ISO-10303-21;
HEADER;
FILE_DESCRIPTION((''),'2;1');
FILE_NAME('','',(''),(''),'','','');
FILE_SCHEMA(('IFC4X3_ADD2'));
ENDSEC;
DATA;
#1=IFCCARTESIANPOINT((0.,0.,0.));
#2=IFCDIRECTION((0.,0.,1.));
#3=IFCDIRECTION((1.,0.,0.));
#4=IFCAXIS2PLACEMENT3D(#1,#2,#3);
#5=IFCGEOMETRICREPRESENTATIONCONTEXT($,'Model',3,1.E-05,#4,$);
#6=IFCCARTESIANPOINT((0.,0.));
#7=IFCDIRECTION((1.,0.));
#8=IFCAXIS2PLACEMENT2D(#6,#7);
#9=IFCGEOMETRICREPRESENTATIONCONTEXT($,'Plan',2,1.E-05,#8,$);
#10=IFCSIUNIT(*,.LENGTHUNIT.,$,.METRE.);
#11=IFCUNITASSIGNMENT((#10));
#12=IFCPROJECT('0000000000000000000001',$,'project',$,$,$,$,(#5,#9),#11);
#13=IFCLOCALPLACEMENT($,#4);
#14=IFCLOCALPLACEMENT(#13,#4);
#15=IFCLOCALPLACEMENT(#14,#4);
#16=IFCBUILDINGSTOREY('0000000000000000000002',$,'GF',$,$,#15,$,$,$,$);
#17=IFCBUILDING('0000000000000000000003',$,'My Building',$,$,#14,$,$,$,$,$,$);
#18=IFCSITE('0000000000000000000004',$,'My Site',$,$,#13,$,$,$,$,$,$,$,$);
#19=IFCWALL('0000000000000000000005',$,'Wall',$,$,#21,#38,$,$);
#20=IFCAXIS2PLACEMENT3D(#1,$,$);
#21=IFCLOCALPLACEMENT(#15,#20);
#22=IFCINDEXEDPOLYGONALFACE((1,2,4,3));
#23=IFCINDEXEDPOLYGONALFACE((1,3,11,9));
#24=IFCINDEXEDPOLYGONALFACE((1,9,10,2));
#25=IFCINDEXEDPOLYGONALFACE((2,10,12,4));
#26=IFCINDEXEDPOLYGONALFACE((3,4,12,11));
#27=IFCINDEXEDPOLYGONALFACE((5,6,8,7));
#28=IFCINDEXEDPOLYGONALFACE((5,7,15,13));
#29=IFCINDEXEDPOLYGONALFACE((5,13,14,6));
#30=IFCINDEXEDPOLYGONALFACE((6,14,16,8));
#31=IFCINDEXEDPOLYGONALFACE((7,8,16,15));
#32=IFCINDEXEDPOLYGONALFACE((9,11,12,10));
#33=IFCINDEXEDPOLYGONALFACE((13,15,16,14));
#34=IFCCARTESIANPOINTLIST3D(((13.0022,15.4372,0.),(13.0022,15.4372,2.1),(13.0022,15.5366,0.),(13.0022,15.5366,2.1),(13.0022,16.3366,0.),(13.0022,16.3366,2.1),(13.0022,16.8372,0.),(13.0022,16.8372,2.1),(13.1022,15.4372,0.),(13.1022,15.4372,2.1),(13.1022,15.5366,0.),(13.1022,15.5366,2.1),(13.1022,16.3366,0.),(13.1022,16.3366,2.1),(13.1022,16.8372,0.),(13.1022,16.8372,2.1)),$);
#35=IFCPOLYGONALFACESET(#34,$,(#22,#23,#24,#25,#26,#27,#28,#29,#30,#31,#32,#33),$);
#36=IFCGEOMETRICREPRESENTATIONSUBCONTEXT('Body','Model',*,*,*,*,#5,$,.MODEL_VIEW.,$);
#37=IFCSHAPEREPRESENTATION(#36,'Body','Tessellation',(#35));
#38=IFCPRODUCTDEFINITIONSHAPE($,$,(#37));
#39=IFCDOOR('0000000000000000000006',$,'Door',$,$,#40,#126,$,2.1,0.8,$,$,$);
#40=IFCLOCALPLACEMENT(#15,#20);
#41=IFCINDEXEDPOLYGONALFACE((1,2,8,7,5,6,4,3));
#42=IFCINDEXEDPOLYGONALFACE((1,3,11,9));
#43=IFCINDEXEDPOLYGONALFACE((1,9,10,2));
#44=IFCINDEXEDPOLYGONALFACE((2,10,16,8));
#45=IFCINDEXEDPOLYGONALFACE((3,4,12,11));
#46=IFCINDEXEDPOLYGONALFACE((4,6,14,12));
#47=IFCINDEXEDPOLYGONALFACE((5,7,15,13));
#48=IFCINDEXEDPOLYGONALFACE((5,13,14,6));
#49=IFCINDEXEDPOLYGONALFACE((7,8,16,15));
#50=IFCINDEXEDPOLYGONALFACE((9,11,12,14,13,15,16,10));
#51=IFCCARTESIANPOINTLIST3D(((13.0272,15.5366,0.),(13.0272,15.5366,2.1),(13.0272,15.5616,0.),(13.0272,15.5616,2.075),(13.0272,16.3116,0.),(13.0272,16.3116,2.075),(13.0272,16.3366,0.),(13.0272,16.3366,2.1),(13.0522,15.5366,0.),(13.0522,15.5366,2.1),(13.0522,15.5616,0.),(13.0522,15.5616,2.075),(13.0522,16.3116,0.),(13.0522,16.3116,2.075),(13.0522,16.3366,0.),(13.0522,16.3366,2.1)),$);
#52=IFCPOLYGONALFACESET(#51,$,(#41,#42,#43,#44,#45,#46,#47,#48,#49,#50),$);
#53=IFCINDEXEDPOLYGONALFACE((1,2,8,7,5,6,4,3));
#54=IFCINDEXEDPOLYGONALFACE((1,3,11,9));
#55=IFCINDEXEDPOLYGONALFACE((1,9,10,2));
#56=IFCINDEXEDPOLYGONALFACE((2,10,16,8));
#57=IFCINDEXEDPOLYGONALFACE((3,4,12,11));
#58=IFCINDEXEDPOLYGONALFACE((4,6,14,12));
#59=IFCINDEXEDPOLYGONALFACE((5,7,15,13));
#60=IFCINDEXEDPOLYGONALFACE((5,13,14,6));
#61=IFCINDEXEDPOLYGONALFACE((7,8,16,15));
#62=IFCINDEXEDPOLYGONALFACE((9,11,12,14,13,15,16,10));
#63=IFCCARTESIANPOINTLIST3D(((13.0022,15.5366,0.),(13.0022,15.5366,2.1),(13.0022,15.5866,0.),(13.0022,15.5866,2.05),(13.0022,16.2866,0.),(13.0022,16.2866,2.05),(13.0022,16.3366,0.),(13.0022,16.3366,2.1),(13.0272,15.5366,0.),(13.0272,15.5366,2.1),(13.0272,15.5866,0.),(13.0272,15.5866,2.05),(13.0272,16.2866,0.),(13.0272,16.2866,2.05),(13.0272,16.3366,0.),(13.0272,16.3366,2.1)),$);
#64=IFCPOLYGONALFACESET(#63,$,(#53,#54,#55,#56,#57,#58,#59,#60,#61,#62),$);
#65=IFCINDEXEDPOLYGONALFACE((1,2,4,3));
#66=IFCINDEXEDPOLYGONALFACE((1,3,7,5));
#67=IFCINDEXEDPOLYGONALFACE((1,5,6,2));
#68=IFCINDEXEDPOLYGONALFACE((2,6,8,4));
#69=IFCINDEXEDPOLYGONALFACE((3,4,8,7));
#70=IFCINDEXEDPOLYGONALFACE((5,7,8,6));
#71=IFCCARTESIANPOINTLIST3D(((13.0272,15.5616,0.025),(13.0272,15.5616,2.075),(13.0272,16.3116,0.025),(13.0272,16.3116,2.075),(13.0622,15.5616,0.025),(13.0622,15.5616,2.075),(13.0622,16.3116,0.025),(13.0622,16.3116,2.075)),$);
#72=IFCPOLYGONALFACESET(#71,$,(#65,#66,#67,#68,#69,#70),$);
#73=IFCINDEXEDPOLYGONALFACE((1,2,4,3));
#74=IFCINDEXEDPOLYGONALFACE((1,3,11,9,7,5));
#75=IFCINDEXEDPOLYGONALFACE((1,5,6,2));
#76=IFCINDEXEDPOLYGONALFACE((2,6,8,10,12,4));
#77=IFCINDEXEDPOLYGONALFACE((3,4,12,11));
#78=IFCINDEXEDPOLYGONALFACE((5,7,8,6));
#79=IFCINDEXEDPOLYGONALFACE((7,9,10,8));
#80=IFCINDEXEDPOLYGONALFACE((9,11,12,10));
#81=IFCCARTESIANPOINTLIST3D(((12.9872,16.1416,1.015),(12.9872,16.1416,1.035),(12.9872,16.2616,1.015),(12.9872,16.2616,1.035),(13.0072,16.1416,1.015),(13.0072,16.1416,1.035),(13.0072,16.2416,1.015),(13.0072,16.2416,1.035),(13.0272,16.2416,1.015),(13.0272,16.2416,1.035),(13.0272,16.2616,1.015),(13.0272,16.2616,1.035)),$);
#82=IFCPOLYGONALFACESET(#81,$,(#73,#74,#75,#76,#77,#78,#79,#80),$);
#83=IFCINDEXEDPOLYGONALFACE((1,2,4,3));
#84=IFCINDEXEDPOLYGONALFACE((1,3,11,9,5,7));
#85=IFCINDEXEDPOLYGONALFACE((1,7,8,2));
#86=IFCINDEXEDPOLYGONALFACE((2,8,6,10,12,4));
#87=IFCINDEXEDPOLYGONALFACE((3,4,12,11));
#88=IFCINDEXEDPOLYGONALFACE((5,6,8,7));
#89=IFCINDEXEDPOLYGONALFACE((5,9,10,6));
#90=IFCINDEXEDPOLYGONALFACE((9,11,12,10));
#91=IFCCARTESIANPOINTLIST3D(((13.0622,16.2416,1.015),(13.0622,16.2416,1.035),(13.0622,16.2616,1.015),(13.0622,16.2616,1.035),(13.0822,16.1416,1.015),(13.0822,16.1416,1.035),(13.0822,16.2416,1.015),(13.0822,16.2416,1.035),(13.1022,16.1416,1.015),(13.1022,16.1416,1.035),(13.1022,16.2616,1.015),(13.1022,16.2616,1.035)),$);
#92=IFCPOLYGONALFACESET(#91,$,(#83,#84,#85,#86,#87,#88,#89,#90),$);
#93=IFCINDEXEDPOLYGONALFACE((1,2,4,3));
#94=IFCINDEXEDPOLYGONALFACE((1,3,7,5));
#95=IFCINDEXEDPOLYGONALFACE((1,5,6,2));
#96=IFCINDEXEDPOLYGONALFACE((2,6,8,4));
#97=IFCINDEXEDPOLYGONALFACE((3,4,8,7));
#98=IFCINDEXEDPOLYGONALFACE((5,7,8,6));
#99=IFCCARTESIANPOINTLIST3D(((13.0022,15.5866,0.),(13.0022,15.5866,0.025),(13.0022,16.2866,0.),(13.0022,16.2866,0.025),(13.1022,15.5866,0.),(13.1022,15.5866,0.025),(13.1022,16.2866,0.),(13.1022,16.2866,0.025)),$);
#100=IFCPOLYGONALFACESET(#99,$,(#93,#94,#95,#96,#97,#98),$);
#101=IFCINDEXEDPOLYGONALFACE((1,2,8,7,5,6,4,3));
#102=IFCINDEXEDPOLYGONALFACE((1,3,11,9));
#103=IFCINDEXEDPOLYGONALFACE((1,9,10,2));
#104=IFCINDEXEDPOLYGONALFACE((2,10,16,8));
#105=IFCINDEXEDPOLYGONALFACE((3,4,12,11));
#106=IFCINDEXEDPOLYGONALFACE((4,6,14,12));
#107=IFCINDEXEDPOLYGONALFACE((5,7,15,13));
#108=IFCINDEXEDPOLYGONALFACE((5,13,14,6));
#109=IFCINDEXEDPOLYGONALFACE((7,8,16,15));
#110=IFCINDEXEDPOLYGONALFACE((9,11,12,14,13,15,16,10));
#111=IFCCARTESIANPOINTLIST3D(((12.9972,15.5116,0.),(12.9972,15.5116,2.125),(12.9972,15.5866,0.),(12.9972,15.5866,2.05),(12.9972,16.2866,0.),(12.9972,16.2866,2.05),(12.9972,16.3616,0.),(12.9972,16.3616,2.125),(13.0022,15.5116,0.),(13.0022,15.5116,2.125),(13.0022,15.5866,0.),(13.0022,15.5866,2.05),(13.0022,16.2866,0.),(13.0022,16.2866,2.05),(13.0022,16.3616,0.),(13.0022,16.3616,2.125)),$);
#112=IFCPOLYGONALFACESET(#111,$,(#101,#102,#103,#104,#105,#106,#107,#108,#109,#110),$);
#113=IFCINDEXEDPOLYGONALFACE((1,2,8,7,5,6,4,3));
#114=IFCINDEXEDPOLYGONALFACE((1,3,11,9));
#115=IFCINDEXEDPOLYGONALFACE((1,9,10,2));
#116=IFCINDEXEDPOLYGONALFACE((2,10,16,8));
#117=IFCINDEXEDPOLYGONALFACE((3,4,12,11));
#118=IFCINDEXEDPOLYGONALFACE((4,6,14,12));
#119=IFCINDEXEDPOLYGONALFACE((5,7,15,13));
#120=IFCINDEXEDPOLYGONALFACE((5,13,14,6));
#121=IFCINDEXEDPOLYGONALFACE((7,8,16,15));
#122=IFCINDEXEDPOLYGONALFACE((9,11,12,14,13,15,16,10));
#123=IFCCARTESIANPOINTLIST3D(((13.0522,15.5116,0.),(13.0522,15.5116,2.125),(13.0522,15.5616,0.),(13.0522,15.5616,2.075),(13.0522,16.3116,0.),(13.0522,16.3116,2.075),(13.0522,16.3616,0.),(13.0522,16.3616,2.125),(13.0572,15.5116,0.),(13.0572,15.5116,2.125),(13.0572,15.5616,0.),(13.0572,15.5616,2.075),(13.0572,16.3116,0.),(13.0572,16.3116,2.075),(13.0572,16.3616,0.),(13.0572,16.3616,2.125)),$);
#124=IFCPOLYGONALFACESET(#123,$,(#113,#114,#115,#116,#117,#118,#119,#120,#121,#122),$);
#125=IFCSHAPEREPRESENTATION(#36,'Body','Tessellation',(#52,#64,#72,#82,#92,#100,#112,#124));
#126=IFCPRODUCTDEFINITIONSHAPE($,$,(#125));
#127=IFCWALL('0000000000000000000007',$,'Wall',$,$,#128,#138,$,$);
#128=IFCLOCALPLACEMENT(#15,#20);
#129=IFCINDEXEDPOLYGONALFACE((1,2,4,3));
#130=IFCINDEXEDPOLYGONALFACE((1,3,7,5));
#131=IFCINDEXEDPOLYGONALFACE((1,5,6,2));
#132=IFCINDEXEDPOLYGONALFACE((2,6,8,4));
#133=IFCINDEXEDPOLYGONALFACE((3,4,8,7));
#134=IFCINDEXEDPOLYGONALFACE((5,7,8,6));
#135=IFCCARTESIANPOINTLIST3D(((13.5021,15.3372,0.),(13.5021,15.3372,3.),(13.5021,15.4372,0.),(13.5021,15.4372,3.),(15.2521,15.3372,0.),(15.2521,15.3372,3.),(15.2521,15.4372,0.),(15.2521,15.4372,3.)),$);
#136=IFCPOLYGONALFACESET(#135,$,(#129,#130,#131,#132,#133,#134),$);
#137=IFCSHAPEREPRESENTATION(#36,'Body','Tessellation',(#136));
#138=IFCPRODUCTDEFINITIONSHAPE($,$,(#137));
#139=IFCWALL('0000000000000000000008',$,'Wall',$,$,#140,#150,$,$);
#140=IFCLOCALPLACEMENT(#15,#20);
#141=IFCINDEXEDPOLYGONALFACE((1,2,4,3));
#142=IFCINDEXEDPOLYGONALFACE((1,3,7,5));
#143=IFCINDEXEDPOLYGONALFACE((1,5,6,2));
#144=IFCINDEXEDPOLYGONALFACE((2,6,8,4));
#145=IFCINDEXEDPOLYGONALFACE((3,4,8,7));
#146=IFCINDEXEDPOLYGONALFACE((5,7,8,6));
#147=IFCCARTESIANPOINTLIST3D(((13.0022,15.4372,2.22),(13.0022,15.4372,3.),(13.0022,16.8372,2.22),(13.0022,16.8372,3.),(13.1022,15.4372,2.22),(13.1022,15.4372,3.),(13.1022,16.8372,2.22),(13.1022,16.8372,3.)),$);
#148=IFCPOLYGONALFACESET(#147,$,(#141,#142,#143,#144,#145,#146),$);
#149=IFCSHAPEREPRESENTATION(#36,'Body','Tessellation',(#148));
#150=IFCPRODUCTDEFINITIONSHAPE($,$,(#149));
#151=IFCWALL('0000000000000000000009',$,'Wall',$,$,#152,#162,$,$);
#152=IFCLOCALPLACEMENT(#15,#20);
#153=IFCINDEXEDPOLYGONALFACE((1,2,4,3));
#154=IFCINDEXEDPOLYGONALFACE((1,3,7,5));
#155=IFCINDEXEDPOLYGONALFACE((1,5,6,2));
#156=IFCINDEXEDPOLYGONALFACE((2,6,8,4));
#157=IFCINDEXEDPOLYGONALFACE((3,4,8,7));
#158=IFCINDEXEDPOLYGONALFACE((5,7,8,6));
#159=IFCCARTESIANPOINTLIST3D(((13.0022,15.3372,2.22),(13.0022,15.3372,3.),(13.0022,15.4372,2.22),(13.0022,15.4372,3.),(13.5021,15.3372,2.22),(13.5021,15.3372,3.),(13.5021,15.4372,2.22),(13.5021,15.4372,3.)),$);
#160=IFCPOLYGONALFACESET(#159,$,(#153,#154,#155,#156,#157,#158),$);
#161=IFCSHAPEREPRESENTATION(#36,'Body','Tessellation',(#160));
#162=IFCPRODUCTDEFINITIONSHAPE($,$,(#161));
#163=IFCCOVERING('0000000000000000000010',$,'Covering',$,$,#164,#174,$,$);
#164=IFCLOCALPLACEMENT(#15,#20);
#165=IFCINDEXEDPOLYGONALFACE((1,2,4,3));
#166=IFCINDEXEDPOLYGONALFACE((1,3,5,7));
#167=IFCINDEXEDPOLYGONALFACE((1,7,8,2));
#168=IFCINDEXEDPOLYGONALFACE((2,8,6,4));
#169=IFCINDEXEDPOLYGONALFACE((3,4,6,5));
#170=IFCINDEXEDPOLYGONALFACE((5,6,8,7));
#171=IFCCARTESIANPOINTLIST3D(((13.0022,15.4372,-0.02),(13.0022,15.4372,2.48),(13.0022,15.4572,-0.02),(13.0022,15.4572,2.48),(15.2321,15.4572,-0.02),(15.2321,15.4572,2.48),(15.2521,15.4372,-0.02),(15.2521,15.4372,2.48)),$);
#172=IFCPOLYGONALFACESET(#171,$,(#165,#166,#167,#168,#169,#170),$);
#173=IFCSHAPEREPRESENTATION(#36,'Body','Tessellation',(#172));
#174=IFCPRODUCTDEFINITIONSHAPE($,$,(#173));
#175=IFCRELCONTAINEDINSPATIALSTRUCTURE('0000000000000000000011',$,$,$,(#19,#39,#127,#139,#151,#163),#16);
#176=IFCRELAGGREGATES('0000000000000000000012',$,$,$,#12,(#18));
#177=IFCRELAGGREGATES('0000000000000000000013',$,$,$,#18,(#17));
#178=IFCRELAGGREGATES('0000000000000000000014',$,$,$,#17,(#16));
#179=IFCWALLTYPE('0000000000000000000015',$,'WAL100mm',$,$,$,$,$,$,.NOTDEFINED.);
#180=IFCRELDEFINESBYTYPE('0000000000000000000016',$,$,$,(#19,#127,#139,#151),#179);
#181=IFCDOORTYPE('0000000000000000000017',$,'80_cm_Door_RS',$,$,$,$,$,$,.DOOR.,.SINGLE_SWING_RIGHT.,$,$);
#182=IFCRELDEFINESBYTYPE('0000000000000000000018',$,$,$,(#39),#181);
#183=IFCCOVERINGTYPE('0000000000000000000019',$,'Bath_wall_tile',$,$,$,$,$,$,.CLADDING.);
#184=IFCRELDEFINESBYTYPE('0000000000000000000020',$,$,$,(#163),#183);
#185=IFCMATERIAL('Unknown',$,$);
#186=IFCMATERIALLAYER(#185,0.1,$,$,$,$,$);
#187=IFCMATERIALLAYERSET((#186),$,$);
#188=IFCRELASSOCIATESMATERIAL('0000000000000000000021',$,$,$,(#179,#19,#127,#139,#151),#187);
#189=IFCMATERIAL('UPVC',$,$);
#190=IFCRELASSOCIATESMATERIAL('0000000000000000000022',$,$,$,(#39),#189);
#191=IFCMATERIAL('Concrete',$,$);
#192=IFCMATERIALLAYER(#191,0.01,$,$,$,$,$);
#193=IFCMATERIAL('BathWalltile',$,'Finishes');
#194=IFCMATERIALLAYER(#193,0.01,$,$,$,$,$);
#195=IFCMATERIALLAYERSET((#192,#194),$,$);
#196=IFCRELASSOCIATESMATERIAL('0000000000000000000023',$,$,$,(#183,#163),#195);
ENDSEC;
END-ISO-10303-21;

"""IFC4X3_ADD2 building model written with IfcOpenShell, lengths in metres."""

from ifc_helpers import new_model, entity, si_unit, frame, origin_with_axes, origin_2d_with_axis, place, context, subcontext, project, spatial, line, indexed_curve, outline, extrude, shape, source, transform, mapped, material, layer, layer_set, layer_usage, type_object, type_shapes, element, fill, save


model = new_model("IFC4X3_ADD2")

# Units and contexts
model_context = context("Model", 3, precision=1e-05, world=origin_with_axes())
plan_context = context("Plan", 2, precision=1e-05, world=origin_2d_with_axis())
body_context_1 = subcontext(model_context, "Body", "Model", "MODEL_VIEW")
body_context_2 = subcontext(plan_context, "Body", "Plan", "PLAN_VIEW")
ifc_project = project(units=[si_unit("LENGTHUNIT", "METRE")], contexts=[model_context, plan_context])

# Site, building, storey
site_placement = place(None, origin_with_axes())
site = spatial("IfcSite", under=ifc_project, at=site_placement, Name="My Site")
building_placement = place(site_placement, origin_with_axes())
building = spatial("IfcBuilding", under=site, at=building_placement, Name="My Building")
storey_placement = place(building_placement, origin_with_axes())
storey = spatial("IfcBuildingStorey", under=building, at=storey_placement, Name="GF")

# Shared definitions
ifc_material_1 = material(Name="UPVC")

# Shared definitions
ifc_material_2 = material(Name="Unknown")
ifc_layer_1 = layer(ifc_material_2, 0.1)
ifc_layer_set_1 = layer_set([ifc_layer_1])
wall_type_1 = type_object("IfcWallType", Name="WAL100mm", PredefinedType="NOTDEFINED", material=ifc_layer_set_1)

# Wall, opening, door
ifc_layer_usage_1 = layer_usage(ifc_layer_set_1, "AXIS2", "POSITIVE", 0.0)
wall_1_placement = place(storey_placement, frame((13.0022, 16.8372, 0.0), z_axis=(0.0, 0.0, 1.0), x_axis=(0.0, -1.0, 0.0)))
wall_1 = element("IfcWall", 1, at=wall_1_placement, inside=storey, type_object=wall_type_1, material=ifc_layer_usage_1, Name="Wall", context=body_context_1, shape_type="SweptSolid", body=[
    extrude(outline(indexed_curve([(0.0, 0.0), (0.0, 0.1), (1.4, 0.1), (1.4, 0.0)], segments=[line(1, 2, 3, 4, 1)])), origin_with_axes(), (0.0, 0.0, 1.0), 2.1),
])
shared_shape_1 = source(origin_with_axes(), body_context_1, "Body", "SweptSolid", [
    extrude(outline(indexed_curve([(0.0, 0.0), (0.8, 0.0), (0.8, 2.1), (0.0, 2.1)], segments=[line(1, 2, 3, 4, 1)])), frame((0.0, -0.6, 0.0), z_axis=(0.0, -1.0, 0.0), x_axis=(1.0, 0.0, 0.0)), (0.0, 0.0, -1.0), 1.2),
])
opening_1_placement = place(wall_1_placement, frame((0.5006, 0.0, 0.0), z_axis=(0.0, 0.0, 1.0), x_axis=(1.0, 0.0, 0.0)))
opening_1 = element("IfcOpeningElement", 2, at=opening_1_placement, cuts=wall_1, PredefinedType="OPENING", context=body_context_1, shape_type="MappedRepresentation", body=[
    mapped(shared_shape_1, transform((0.0, 0.0, 0.0), x_axis=(1.0, 0.0, 0.0), y_axis=(0.0, 1.0, 0.0), z_axis=(0.0, 0.0, 1.0), scale=1.0)),
])
door_type_1 = type_object("IfcDoorType", Name="80_cm_Door_RS", OperationType="SINGLE_SWING_RIGHT", PredefinedType="DOOR")
shared_shape_2 = source(origin_with_axes(), body_context_1, "Body", "SweptSolid", [
    extrude(outline(indexed_curve([(0.0, 0.0), (0.0, 2.1), (0.8, 2.1), (0.8, 0.0), (0.775, 0.0), (0.775, 2.075), (0.025, 2.075), (0.025, 0.0)], segments=[line(1, 2, 3, 4, 5, 6, 7, 8, 1)])), frame((0.0, 0.025, 0.0), z_axis=(0.0, -1.0, 0.0), x_axis=(1.0, 0.0, 0.0)), (0.0, 0.0, -1.0), 0.025),
    extrude(outline(indexed_curve([(0.0, 0.0), (0.0, 2.1), (0.8, 2.1), (0.8, 0.0), (0.75, 0.0), (0.75, 2.05), (0.05, 2.05), (0.05, 0.0)], segments=[line(1, 2, 3, 4, 5, 6, 7, 8, 1)])), frame((0.0, 0.0, 0.0), z_axis=(0.0, -1.0, 0.0), x_axis=(1.0, 0.0, 0.0)), (0.0, 0.0, -1.0), 0.025),
    extrude(outline(indexed_curve([(0.0, 0.0), (0.75, 0.0), (0.75, 0.035), (0.0, 0.035)], segments=[line(1, 2, 3, 4, 1)])), frame((0.025, 0.025, 0.025), z_axis=(0.0, 0.0, 1.0), x_axis=(1.0, 0.0, 0.0)), (0.0, 0.0, 1.0), 2.05),
    extrude(outline(indexed_curve([(0.0, 0.0), (0.0, -0.04), (0.12, -0.04), (0.12, -0.02), (0.02, -0.02), (0.02, 0.0)], segments=[line(1, 2, 3, 4, 5, 6, 1)])), frame((0.075, 0.025, 1.015), z_axis=(0.0, 0.0, 1.0), x_axis=(1.0, 0.0, 0.0)), (0.0, 0.0, 1.0), 0.02),
    extrude(outline(indexed_curve([(0.0, 0.0), (0.0, 0.04), (0.12, 0.04), (0.12, 0.02), (0.02, 0.02), (0.02, 0.0)], segments=[line(1, 2, 3, 4, 5, 6, 1)])), frame((0.075, 0.06, 1.015), z_axis=(0.0, 0.0, 1.0), x_axis=(1.0, 0.0, 0.0)), (0.0, 0.0, 1.0), 0.02),
    extrude(outline(indexed_curve([(0.0, 0.0), (0.7, 0.0), (0.7, 0.1), (0.0, 0.1)], segments=[line(1, 2, 3, 4, 1)])), frame((0.05, 0.0, 0.0), z_axis=(0.0, 0.0, 1.0), x_axis=(1.0, 0.0, 0.0)), (0.0, 0.0, 1.0), 0.025),
    extrude(outline(indexed_curve([(0.0, 0.0), (0.0, 2.125), (0.85, 2.125), (0.85, 0.0), (0.775, 0.0), (0.775, 2.05), (0.075, 2.05), (0.075, 0.0)], segments=[line(1, 2, 3, 4, 5, 6, 7, 8, 1)])), frame((-0.025, -0.005, 0.0), z_axis=(0.0, -1.0, 0.0), x_axis=(1.0, 0.0, 0.0)), (0.0, 0.0, -1.0), 0.005),
    extrude(outline(indexed_curve([(0.0, 0.0), (0.0, 2.125), (0.85, 2.125), (0.85, 0.0), (0.8, 0.0), (0.8, 2.075), (0.05, 2.075), (0.05, 0.0)], segments=[line(1, 2, 3, 4, 5, 6, 7, 8, 1)])), frame((-0.025, 0.05, 0.0), z_axis=(0.0, -1.0, 0.0), x_axis=(1.0, 0.0, 0.0)), (0.0, 0.0, -1.0), 0.005),
])
shared_shape_3 = source(origin_with_axes(), body_context_2, "Body", "Curve2D", [
    entity("IfcIndexedPolyCurve", entity("IfcCartesianPointList2D", [[0.0, 0.0], [0.0, 0.05], [0.025, 0.05], [0.025, 0.025], [0.05, 0.025], [0.05, 0.0]]), [entity("IfcLineIndex", [1, 2, 3, 4, 5, 6, 1])]),
    entity("IfcIndexedPolyCurve", entity("IfcCartesianPointList2D", [[0.8, 0.0], [0.8, 0.05], [0.775, 0.05], [0.775, 0.025], [0.75, 0.025], [0.75, 0.0]]), [entity("IfcLineIndex", [1, 2, 3, 4, 5, 6, 1])]),
    entity("IfcTrimmedCurve", entity("IfcEllipse", entity("IfcAxis2Placement2D", entity("IfcCartesianPoint", [0.74, 0.05]), entity("IfcDirection", [1.0, 0.0])), 0.715, 0.75), [entity("IfcCartesianPoint", [0.74, 0.8])], [entity("IfcCartesianPoint", [0.025, 0.05])], True, "CARTESIAN"),
    entity("IfcIndexedPolyCurve", entity("IfcCartesianPointList2D", [[0.775, 0.05], [0.74, 0.05], [0.74, 0.8], [0.775, 0.8]]), [entity("IfcLineIndex", [1, 2, 3, 4, 1])]),
])
type_shapes(door_type_1, [shared_shape_2, shared_shape_3])
door_1_placement = place(opening_1_placement, origin_with_axes())
door_1 = element("IfcDoor", 3, at=door_1_placement, inside=storey, type_object=door_type_1, material=ifc_material_1, Name="Door", OverallHeight=2.1, OverallWidth=0.8, shapes=[
    shape(body_context_1, "Body", "MappedRepresentation", [mapped(shared_shape_2, transform((0.0, 0.0, 0.0), x_axis=(1.0, 0.0, 0.0), y_axis=(0.0, 1.0, 0.0), z_axis=(0.0, 0.0, 1.0), scale=1.0))]),
    shape(body_context_2, "Body", "MappedRepresentation", [mapped(shared_shape_3, transform((0.0, 0.0, 0.0), x_axis=(1.0, 0.0, 0.0), y_axis=(0.0, 1.0, 0.0), z_axis=(0.0, 0.0, 1.0), scale=1.0))]),
])
fill(opening_1, door_1)

# Walls
ifc_layer_usage_2 = layer_usage(ifc_layer_set_1, "AXIS2", "POSITIVE", 0.0)
wall_2_placement = place(storey_placement, frame((13.5021, 15.3372, 0.0), z_axis=(0.0, 0.0, 1.0), x_axis=(1.0, 0.0, 0.0)))
element("IfcWall", 4, at=wall_2_placement, inside=storey, type_object=wall_type_1, material=ifc_layer_usage_2, Name="Wall", context=body_context_1, shape_type="SweptSolid", body=[
    extrude(outline(indexed_curve([(0.0, 0.0), (0.0, 0.1), (1.75, 0.1), (1.75, 0.0)], segments=[line(1, 2, 3, 4, 1)])), origin_with_axes(), (0.0, 0.0, 1.0), 3.0),
])
ifc_layer_usage_3 = layer_usage(ifc_layer_set_1, "AXIS2", "POSITIVE", 0.0)
wall_3_placement = place(storey_placement, frame((13.0022, 16.8372, 2.22), z_axis=(0.0, 0.0, 1.0), x_axis=(0.0, -1.0, 0.0)))
element("IfcWall", 5, at=wall_3_placement, inside=storey, type_object=wall_type_1, material=ifc_layer_usage_3, Name="Wall", context=body_context_1, shape_type="SweptSolid", body=[
    extrude(outline(indexed_curve([(0.0, 0.0), (0.0, 0.1), (1.4, 0.1), (1.4, 0.0)], segments=[line(1, 2, 3, 4, 1)])), origin_with_axes(), (0.0, 0.0, 1.0), 0.78),
])
ifc_layer_usage_4 = layer_usage(ifc_layer_set_1, "AXIS2", "POSITIVE", 0.0)
wall_4_placement = place(storey_placement, frame((13.0022, 15.3372, 2.22), z_axis=(0.0, 0.0, 1.0), x_axis=(1.0, 0.0, 0.0)))
element("IfcWall", 6, at=wall_4_placement, inside=storey, type_object=wall_type_1, material=ifc_layer_usage_4, Name="Wall", context=body_context_1, shape_type="SweptSolid", body=[
    extrude(outline(indexed_curve([(0.0, 0.0), (0.0, 0.1), (0.4999, 0.1), (0.4999, 0.0)], segments=[line(1, 2, 3, 4, 1)])), origin_with_axes(), (0.0, 0.0, 1.0), 0.78),
])

# Covering
ifc_material_3 = material(Name="Concrete")
ifc_layer_2 = layer(ifc_material_3, 0.01)
ifc_material_4 = material(Name="BathWalltile", Category="Finishes")
ifc_layer_3 = layer(ifc_material_4, 0.01)
ifc_layer_set_2 = layer_set([ifc_layer_2, ifc_layer_3])
ifc_layer_usage_5 = layer_usage(ifc_layer_set_2, "AXIS2", "NEGATIVE", 0.0)
covering_type = type_object("IfcCoveringType", Name="Bath_wall_tile", PredefinedType="CLADDING", material=ifc_layer_set_2)
covering_1_placement = place(storey_placement, frame((15.2521, 15.4372, -0.02), z_axis=(0.0, 0.0, 1.0), x_axis=(-1.0, 0.0, 0.0)))
element("IfcCovering", 7, at=covering_1_placement, inside=storey, type_object=covering_type, material=ifc_layer_usage_5, Name="Covering", context=body_context_1, shape_type="SweptSolid", body=[
    extrude(outline(indexed_curve([(0.02, -0.02), (0.0, 0.0), (2.2499, 0.0), (2.2499, -0.02)], segments=[line(1, 2, 3, 4, 1)])), origin_with_axes(), (0.0, 0.0, 1.0), 2.5),
])

save(model, "model.ifc")
